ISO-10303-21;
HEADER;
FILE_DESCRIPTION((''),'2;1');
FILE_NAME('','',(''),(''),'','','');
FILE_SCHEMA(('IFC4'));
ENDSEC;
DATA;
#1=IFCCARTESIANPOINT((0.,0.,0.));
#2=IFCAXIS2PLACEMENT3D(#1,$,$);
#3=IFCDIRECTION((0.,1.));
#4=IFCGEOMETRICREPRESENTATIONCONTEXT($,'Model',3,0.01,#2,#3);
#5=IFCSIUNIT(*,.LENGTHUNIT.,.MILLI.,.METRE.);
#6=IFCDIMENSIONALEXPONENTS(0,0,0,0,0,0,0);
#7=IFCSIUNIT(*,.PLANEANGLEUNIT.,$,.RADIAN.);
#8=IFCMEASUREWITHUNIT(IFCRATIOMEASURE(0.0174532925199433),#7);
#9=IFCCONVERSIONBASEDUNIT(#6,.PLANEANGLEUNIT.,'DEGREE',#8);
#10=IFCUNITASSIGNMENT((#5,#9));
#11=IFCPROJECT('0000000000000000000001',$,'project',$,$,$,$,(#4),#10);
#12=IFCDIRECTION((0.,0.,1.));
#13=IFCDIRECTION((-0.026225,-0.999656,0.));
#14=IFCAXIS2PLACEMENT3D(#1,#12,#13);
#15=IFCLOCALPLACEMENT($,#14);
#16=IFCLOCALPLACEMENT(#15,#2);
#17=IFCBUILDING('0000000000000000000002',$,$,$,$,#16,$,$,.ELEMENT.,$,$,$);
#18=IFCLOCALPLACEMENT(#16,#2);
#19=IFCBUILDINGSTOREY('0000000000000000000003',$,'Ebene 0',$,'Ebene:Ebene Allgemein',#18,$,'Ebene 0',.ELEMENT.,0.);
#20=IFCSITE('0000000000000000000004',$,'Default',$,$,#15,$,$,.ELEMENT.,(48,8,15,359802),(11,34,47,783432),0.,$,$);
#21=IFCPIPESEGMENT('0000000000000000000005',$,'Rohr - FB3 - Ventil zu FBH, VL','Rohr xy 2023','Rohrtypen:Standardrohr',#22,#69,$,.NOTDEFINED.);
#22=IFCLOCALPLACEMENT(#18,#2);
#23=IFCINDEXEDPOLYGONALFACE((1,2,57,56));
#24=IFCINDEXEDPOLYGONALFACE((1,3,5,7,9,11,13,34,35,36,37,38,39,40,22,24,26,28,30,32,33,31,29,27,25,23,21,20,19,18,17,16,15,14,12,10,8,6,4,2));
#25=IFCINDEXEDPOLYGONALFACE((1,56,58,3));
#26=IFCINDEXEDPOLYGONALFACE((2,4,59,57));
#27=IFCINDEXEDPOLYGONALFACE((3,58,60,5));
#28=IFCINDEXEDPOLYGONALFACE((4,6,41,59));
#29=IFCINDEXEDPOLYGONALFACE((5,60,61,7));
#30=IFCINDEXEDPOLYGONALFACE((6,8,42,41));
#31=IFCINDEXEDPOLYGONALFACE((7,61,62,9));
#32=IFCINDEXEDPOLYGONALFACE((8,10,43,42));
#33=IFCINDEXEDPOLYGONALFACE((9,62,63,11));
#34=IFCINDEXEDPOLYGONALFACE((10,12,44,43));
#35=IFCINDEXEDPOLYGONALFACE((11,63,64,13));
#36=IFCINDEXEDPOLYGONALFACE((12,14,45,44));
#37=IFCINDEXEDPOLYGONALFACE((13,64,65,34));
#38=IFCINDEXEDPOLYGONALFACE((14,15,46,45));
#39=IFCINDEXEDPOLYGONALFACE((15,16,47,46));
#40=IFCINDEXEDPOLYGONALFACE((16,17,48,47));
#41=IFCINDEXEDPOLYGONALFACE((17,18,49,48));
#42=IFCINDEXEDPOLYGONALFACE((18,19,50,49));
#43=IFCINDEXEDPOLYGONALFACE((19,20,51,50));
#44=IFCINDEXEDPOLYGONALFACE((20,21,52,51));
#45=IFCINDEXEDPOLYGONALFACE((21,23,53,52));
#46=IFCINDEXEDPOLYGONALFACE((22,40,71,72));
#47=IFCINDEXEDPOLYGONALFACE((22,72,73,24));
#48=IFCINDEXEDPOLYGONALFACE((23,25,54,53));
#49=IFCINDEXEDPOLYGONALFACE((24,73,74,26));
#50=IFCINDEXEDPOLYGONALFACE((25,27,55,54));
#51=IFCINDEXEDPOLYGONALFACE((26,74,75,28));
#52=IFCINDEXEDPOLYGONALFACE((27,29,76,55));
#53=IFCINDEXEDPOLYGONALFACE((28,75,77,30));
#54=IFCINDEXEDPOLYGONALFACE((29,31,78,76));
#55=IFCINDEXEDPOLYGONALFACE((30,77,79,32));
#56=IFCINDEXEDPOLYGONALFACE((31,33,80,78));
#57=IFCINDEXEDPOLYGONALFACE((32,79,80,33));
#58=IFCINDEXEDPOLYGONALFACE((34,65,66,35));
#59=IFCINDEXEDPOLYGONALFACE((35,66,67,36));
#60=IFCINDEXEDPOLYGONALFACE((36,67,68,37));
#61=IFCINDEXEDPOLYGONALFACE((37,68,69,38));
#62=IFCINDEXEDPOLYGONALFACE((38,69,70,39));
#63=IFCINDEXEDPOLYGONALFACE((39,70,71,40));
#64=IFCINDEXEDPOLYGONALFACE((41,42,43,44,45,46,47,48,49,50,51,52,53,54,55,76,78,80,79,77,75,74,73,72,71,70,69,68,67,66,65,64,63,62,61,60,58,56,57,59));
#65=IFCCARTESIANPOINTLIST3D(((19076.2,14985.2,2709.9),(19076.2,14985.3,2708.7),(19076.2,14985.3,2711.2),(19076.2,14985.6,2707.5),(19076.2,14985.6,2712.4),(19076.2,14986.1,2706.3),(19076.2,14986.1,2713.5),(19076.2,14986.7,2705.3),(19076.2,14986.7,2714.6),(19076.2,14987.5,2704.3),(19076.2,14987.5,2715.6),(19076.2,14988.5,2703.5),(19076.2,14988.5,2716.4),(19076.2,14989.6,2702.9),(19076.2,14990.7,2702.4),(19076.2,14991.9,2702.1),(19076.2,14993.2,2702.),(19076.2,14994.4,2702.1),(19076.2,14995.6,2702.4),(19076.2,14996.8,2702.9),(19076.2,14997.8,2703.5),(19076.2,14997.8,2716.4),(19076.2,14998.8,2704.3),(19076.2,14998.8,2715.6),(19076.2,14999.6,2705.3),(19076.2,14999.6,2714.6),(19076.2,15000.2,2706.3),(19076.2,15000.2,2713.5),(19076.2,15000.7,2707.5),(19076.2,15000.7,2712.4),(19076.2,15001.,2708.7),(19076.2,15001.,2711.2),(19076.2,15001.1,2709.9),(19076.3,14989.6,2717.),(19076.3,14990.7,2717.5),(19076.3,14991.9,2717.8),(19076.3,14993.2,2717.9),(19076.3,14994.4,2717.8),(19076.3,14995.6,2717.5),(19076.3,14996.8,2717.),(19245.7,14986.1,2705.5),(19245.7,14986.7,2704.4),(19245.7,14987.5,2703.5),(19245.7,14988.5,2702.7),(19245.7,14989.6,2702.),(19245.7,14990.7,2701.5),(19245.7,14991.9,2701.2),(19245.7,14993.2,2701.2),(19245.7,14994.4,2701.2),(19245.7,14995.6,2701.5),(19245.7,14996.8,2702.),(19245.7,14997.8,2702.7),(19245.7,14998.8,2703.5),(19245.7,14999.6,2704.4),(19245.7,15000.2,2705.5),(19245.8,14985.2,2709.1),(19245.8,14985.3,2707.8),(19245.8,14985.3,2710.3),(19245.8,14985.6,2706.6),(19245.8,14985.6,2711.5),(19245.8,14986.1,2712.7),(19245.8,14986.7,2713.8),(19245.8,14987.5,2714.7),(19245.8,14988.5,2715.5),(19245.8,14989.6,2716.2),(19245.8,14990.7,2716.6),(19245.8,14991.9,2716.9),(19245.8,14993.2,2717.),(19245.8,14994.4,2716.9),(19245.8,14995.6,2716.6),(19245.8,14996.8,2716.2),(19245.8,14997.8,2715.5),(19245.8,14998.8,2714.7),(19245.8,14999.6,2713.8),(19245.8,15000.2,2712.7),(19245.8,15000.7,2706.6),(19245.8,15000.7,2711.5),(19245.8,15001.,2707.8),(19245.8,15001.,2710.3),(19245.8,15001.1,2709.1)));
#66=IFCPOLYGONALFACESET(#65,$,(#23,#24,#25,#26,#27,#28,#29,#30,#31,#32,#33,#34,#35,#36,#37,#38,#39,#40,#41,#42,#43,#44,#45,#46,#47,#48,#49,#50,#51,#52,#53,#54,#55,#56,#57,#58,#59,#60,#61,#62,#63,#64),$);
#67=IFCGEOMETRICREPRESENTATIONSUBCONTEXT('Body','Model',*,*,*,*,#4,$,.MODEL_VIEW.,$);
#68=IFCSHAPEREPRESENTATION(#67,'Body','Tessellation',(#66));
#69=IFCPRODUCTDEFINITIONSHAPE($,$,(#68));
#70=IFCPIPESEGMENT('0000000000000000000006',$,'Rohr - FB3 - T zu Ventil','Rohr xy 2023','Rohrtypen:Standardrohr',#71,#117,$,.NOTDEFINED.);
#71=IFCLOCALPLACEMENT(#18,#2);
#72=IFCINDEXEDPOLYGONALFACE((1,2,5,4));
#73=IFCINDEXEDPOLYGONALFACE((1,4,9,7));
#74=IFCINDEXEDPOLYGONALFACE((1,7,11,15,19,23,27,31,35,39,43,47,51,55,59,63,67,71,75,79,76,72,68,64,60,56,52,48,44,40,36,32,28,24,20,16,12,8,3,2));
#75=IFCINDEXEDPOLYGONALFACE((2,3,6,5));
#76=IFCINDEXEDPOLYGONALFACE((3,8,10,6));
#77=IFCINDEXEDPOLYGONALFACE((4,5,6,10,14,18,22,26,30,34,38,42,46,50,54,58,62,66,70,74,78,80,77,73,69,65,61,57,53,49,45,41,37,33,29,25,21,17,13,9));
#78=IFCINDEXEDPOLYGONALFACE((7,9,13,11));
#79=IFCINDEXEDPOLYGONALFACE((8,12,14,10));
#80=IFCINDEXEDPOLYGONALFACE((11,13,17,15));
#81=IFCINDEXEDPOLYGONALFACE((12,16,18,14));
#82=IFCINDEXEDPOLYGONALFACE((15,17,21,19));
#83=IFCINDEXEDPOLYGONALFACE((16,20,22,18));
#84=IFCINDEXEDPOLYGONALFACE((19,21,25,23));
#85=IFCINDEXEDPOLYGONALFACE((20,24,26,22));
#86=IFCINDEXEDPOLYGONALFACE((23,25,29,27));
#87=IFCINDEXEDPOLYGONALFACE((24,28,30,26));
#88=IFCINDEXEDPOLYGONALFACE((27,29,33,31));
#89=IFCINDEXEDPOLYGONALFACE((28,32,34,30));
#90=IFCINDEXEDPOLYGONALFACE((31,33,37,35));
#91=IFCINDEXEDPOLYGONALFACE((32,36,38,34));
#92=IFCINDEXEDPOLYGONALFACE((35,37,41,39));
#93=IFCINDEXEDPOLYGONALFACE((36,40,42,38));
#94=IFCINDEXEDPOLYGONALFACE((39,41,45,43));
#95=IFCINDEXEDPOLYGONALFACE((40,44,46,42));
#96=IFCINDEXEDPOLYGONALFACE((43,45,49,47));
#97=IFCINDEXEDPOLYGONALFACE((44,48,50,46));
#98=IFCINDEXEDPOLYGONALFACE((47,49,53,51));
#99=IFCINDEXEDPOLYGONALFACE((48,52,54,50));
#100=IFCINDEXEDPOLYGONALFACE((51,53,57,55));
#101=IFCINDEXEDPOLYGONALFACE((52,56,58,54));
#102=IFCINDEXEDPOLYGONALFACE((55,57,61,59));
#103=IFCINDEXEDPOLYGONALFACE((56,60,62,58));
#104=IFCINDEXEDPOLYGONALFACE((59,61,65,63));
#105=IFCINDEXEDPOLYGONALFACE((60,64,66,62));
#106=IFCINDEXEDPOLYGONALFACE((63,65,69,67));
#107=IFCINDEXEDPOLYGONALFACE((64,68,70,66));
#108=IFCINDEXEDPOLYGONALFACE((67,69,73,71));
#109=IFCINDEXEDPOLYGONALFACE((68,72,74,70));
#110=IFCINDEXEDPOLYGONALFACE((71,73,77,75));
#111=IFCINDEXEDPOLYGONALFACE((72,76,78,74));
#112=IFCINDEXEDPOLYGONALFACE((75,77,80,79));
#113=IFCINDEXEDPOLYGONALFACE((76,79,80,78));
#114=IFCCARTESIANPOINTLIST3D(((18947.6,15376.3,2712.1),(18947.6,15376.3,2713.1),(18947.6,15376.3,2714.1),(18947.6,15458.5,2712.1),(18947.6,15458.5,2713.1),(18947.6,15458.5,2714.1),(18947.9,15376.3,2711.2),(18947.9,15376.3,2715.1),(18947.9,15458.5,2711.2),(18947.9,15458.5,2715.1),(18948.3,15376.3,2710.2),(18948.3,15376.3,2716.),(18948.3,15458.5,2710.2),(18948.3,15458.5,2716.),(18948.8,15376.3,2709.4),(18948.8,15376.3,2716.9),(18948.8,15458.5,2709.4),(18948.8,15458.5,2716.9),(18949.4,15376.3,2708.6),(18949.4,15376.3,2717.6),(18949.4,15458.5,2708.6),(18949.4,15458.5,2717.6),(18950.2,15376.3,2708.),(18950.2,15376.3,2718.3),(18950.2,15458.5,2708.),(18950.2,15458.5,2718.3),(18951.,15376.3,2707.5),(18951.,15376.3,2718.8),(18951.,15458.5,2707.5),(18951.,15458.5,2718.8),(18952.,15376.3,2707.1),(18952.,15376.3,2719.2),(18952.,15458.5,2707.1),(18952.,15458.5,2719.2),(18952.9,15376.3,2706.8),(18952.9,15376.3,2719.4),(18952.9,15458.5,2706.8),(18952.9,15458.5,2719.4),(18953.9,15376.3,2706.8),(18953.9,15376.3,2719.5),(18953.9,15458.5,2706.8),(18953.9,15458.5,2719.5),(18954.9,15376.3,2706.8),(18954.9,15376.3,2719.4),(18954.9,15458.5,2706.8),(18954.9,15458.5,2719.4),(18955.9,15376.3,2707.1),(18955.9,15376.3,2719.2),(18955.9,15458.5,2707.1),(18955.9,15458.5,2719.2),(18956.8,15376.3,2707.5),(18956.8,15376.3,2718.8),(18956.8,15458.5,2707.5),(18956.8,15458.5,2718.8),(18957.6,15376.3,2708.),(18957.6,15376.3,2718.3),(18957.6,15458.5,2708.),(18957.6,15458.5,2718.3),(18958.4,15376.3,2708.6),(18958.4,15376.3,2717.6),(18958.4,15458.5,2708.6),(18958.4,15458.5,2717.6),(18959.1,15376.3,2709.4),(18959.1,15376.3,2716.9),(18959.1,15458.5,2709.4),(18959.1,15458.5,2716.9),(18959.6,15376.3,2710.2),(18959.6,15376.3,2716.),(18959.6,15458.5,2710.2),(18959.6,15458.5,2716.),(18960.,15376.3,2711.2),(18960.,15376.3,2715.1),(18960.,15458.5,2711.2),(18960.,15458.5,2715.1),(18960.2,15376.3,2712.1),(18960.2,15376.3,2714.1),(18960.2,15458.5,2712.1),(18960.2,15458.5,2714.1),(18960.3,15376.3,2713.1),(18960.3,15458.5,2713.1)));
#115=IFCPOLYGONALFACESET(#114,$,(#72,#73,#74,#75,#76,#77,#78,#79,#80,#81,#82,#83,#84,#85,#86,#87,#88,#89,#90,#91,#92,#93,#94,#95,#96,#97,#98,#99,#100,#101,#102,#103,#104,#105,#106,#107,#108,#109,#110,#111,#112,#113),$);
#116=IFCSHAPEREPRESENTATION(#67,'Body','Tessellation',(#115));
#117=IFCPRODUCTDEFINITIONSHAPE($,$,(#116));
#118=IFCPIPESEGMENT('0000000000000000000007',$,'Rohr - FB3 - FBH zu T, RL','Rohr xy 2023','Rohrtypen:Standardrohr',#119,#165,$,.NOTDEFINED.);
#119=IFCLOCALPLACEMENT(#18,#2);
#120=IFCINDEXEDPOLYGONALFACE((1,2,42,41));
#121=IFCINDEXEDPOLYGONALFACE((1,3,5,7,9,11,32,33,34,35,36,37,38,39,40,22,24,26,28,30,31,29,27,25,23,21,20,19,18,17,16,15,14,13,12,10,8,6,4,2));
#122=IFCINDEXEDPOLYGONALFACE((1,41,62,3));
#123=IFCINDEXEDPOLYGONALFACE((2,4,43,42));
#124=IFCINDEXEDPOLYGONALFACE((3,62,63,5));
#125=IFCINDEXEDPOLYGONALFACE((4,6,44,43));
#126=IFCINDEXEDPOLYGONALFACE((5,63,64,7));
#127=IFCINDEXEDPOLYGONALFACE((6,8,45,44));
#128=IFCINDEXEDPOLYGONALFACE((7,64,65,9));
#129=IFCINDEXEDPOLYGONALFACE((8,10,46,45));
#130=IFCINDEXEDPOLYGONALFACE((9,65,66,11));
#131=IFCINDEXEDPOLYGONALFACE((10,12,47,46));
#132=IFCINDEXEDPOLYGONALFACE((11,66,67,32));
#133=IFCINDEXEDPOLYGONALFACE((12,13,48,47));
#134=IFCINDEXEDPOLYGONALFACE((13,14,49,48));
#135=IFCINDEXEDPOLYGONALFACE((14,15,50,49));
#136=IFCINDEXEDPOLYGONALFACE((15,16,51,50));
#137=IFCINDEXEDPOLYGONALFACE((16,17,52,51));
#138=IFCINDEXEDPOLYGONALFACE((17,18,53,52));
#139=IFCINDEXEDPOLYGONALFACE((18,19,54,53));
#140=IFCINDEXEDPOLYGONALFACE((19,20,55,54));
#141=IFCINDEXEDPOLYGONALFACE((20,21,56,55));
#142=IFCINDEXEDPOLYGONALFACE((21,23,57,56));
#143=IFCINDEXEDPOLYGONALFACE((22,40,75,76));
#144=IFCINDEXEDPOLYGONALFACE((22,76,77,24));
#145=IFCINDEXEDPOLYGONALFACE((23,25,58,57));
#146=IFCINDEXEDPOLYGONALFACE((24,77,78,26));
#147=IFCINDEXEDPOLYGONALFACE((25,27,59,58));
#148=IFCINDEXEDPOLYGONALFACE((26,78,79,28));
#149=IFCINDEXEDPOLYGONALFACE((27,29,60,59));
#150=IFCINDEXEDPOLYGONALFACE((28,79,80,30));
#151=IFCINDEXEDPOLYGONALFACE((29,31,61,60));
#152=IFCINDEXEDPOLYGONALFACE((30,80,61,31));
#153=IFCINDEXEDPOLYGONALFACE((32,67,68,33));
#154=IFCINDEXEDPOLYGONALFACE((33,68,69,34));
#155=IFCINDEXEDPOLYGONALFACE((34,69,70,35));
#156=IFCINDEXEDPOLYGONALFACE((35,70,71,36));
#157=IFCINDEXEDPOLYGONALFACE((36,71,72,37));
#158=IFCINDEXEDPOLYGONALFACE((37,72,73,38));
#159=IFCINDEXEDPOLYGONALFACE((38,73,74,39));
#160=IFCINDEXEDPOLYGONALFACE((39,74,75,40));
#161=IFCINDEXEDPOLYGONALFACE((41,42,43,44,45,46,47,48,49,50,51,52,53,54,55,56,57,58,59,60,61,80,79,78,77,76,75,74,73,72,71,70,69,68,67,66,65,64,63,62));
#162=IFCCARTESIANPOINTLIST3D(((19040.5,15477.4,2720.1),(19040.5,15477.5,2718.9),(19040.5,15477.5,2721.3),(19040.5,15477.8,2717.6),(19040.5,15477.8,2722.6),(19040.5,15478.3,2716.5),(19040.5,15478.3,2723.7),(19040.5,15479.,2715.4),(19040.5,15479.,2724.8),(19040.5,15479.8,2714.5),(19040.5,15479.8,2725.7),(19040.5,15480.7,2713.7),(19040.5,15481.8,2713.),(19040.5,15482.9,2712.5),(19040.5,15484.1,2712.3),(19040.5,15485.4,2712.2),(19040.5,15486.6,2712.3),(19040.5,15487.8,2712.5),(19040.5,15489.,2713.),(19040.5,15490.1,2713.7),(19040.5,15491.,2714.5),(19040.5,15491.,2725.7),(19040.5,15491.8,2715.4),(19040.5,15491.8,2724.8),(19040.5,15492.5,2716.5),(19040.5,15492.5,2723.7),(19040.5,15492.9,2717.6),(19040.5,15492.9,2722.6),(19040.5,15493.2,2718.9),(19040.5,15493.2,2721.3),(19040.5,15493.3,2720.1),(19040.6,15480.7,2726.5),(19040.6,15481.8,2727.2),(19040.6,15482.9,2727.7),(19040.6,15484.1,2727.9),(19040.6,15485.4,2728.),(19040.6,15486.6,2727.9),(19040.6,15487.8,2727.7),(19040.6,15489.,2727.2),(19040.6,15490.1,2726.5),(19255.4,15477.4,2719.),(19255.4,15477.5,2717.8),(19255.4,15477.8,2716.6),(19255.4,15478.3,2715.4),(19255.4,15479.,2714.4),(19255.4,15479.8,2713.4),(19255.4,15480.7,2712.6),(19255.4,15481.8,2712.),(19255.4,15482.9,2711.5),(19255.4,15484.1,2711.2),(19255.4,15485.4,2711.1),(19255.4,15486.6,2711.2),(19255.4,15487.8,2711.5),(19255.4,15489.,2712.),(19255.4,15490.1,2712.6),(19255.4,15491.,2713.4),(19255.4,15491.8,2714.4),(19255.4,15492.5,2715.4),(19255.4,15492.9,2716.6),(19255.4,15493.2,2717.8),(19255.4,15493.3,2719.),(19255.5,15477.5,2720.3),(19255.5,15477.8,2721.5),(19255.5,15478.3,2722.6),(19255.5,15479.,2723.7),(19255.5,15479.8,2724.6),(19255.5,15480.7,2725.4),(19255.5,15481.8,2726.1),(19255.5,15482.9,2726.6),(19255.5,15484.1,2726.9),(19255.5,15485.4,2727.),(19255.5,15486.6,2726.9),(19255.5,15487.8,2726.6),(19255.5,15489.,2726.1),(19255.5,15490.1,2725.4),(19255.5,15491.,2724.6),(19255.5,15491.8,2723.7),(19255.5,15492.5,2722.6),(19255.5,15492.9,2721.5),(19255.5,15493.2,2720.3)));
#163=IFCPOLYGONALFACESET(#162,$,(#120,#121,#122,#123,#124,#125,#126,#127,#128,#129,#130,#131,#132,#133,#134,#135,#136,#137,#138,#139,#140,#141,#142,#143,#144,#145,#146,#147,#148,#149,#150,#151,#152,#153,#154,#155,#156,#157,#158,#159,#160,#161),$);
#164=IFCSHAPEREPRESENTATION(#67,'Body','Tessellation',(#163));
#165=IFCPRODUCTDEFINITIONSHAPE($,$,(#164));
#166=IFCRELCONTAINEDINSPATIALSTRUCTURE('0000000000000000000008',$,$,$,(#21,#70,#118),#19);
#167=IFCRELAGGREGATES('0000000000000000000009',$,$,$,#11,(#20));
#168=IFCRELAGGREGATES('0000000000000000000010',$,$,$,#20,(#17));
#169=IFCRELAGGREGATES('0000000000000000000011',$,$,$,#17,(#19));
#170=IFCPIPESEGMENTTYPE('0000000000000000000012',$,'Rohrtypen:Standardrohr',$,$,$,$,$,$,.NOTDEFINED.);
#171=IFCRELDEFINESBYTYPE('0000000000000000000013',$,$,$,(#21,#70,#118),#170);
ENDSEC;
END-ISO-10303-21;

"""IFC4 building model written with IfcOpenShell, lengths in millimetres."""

from ifc_helpers import new_model, entity, si_unit, converted_unit, direction, frame, origin, place, context, subcontext, project, spatial, indexed_curve, outline, extrude, type_object, element, save


model = new_model("IFC4")

# Units and contexts
model_context = context("Model", 3, precision=0.01, world=origin(), true_north=direction((0.0, 1.0)))
body_context = subcontext(model_context, "Body", "Model", "MODEL_VIEW")
ifc_project = project(units=[si_unit("LENGTHUNIT", "METRE", prefix="MILLI"), converted_unit("PLANEANGLEUNIT", "DEGREE", entity("IfcRatioMeasure", 0.0174532925199433), si_unit("PLANEANGLEUNIT", "RADIAN"), dimensions=[0, 0, 0, 0, 0, 0, 0])], contexts=[model_context])

# Site, building, storey
site_placement = place(None, frame((0.0, 0.0, 0.0), z_axis=(0.0, 0.0, 1.0), x_axis=(-0.026225, -0.999656, 0.0)))
site = spatial("IfcSite", under=ifc_project, at=site_placement, Name="Default", CompositionType="ELEMENT", RefLatitude=(48, 8, 15, 359802), RefLongitude=(11, 34, 47, 783432), RefElevation=0.0)
building_placement = place(site_placement, origin())
building = spatial("IfcBuilding", under=site, at=building_placement, CompositionType="ELEMENT")
storey_placement = place(building_placement, origin())
storey = spatial("IfcBuildingStorey", under=building, at=storey_placement, Name="Ebene 0", ObjectType="Ebene:Ebene Allgemein", LongName="Ebene 0", CompositionType="ELEMENT", Elevation=0.0)

# Pipe segments
pipe_segment_type = type_object("IfcPipeSegmentType", Name="Rohrtypen:Standardrohr", PredefinedType="NOTDEFINED")
pipe_segment_1_placement = place(storey_placement, origin())
element("IfcPipeSegment", 1, at=pipe_segment_1_placement, inside=storey, type_object=pipe_segment_type, Name="Rohr - FB3 - Ventil zu FBH, VL", Description="Rohr xy 2023", ObjectType="Rohrtypen:Standardrohr", PredefinedType="NOTDEFINED", context=body_context, shape_type="SweptSolid", body=[
    extrude(outline(indexed_curve([(7.9, 0.0), (7.8, 1.2), (7.6, 2.5), (7.1, 3.6), (6.4, 4.7), (5.6, 5.6), (4.7, 6.4), (3.6, 7.1), (2.5, 7.6), (1.2, 7.8), (0.0, 7.9), (-1.2, 7.8), (-2.5, 7.6), (-3.6, 7.1), (-4.7, 6.4), (-5.6, 5.6), (-6.4, 4.7), (-7.1, 3.6), (-7.6, 2.5), (-7.8, 1.2), (-7.9, 0.0), (-7.8, -1.2), (-7.6, -2.5), (-7.1, -3.6), (-6.4, -4.7), (-5.6, -5.6), (-4.7, -6.4), (-3.6, -7.1), (-2.5, -7.6), (-1.2, -7.8), (0.0, -7.9), (1.2, -7.8), (2.5, -7.6), (3.6, -7.1), (4.7, -6.4), (5.6, -5.6), (6.4, -4.7), (7.1, -3.6), (7.6, -2.5), (7.8, -1.2), (7.9, 0.0)], self_intersect=False)), frame((19076.2, 14993.2, 2709.9), z_axis=(0.999988, 0.0, -0.005), x_axis=(0.0, 1.0, 0.0)), (0.0, 0.0, 1.0), 169.5),
])
pipe_segment_2_placement = place(storey_placement, origin())
element("IfcPipeSegment", 2, at=pipe_segment_2_placement, inside=storey, type_object=pipe_segment_type, Name="Rohr - FB3 - T zu Ventil", Description="Rohr xy 2023", ObjectType="Rohrtypen:Standardrohr", PredefinedType="NOTDEFINED", context=body_context, shape_type="SweptSolid", body=[
    extrude(outline(indexed_curve([(6.4, 0.0), (6.3, 1.0), (6.0, 2.0), (5.7, 2.9), (5.1, 3.7), (4.5, 4.5), (3.7, 5.1), (2.9, 5.7), (2.0, 6.0), (1.0, 6.3), (0.0, 6.4), (-1.0, 6.3), (-2.0, 6.0), (-2.9, 5.7), (-3.7, 5.1), (-4.5, 4.5), (-5.1, 3.7), (-5.7, 2.9), (-6.0, 2.0), (-6.3, 1.0), (-6.4, 0.0), (-6.3, -1.0), (-6.0, -2.0), (-5.7, -2.9), (-5.1, -3.7), (-4.5, -4.5), (-3.7, -5.1), (-2.9, -5.7), (-2.0, -6.0), (-1.0, -6.3), (0.0, -6.4), (1.0, -6.3), (2.0, -6.0), (2.9, -5.7), (3.7, -5.1), (4.5, -4.5), (5.1, -3.7), (5.7, -2.9), (6.0, -2.0), (6.3, -1.0), (6.4, 0.0)], self_intersect=False)), frame((18953.9, 15376.3, 2713.1), z_axis=(0.0, 1.0, 0.0), x_axis=(-1.0, 0.0, 0.0)), (0.0, 0.0, 1.0), 82.2),
])
pipe_segment_3_placement = place(storey_placement, origin())
element("IfcPipeSegment", 3, at=pipe_segment_3_placement, inside=storey, type_object=pipe_segment_type, Name="Rohr - FB3 - FBH zu T, RL", Description="Rohr xy 2023", ObjectType="Rohrtypen:Standardrohr", PredefinedType="NOTDEFINED", context=body_context, shape_type="SweptSolid", body=[
    extrude(outline(indexed_curve([(7.9, 0.0), (7.8, 1.2), (7.6, 2.5), (7.1, 3.6), (6.4, 4.7), (5.6, 5.6), (4.7, 6.4), (3.6, 7.1), (2.5, 7.6), (1.2, 7.8), (0.0, 7.9), (-1.2, 7.8), (-2.5, 7.6), (-3.6, 7.1), (-4.7, 6.4), (-5.6, 5.6), (-6.4, 4.7), (-7.1, 3.6), (-7.6, 2.5), (-7.8, 1.2), (-7.9, 0.0), (-7.8, -1.2), (-7.6, -2.5), (-7.1, -3.6), (-6.4, -4.7), (-5.6, -5.6), (-4.7, -6.4), (-3.6, -7.1), (-2.5, -7.6), (-1.2, -7.8), (0.0, -7.9), (1.2, -7.8), (2.5, -7.6), (3.6, -7.1), (4.7, -6.4), (5.6, -5.6), (6.4, -4.7), (7.1, -3.6), (7.6, -2.5), (7.8, -1.2), (7.9, 0.0)], self_intersect=False)), frame((19255.4, 15485.4, 2719.0), z_axis=(-0.999988, 0.0, 0.005), x_axis=(0.0, 1.0, 0.0)), (0.0, 0.0, 1.0), 214.9),
])

save(model, "model.ifc")
